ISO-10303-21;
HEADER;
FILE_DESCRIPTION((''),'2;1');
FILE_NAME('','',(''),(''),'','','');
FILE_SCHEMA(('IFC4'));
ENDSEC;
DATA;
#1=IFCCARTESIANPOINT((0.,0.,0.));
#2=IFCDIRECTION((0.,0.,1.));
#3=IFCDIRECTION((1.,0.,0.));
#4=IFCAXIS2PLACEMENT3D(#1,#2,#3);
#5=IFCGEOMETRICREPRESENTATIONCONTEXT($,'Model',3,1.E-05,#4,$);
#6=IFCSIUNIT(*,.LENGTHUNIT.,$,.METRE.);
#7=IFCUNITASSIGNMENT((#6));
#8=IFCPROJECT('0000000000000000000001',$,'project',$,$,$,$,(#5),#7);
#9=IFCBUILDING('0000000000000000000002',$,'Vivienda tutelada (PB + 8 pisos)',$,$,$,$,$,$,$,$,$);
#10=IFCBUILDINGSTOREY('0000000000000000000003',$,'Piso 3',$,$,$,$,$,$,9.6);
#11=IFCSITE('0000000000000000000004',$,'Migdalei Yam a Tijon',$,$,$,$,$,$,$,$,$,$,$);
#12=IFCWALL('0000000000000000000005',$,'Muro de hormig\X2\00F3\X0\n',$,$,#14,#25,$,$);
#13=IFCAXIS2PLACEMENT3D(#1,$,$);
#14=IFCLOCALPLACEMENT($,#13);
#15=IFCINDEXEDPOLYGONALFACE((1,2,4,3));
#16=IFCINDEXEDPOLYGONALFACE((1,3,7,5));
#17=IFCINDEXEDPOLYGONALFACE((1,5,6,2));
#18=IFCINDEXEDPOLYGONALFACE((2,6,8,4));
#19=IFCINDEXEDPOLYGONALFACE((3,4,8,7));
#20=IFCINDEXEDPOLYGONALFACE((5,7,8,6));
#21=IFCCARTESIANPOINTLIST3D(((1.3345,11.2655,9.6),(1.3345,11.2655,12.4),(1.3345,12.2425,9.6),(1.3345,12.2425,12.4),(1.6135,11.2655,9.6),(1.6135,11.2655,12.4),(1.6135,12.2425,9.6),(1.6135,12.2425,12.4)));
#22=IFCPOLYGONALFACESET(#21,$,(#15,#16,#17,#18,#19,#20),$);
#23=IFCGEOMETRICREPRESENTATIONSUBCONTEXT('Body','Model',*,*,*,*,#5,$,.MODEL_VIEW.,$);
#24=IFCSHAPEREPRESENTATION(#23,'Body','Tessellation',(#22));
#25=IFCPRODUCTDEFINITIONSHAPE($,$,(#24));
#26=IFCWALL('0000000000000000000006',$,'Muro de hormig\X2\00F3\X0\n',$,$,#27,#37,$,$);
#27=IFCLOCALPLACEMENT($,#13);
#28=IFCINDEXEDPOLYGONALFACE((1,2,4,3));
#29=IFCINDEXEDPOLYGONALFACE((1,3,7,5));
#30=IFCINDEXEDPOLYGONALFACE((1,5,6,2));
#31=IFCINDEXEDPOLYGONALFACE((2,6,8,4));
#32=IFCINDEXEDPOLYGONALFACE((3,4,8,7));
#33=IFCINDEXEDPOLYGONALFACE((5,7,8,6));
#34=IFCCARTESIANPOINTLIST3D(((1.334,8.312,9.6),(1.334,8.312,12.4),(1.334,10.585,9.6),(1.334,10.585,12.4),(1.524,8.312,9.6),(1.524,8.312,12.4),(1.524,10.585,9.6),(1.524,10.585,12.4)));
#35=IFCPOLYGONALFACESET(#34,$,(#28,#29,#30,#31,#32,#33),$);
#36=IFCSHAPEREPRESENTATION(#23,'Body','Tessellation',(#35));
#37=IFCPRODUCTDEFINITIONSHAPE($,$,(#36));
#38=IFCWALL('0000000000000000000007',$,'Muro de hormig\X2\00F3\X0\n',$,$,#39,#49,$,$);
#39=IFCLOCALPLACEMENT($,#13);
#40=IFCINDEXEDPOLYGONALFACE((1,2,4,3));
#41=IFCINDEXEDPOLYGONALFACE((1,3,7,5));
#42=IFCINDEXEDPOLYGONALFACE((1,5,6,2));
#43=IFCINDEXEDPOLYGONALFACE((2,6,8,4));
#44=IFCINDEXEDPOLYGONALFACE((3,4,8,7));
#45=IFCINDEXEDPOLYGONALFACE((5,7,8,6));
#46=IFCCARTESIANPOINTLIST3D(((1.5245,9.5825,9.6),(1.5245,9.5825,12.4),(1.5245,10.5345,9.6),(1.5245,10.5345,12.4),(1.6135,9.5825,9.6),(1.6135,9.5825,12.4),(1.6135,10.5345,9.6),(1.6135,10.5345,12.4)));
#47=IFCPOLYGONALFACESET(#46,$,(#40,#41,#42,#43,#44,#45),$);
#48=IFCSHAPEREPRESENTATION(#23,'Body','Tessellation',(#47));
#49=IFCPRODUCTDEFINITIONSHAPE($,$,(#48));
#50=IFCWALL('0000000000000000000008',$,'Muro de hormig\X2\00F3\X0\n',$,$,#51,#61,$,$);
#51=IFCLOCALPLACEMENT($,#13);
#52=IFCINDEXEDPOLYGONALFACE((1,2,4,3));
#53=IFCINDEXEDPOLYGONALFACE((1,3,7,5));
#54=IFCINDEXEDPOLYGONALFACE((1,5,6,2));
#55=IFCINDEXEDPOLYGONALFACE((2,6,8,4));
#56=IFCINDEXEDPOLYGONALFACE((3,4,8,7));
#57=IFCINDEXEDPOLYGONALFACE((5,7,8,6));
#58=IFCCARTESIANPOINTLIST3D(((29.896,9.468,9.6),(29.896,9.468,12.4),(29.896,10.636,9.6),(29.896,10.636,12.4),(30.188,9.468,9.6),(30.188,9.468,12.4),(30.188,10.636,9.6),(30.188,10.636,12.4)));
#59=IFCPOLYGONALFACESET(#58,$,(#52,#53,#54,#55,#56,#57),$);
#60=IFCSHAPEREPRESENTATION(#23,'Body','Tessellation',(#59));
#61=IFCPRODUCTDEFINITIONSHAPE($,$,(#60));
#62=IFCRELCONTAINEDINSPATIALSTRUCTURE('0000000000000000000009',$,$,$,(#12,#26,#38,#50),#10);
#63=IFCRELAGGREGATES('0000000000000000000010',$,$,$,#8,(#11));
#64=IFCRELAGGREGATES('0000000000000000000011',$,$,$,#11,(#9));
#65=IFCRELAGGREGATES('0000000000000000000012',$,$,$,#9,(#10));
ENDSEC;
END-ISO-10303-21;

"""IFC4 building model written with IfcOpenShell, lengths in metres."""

from ifc_helpers import new_model, si_unit, frame, origin_with_axes, context, subcontext, project, spatial, line, indexed_curve, outline, extrude, element, save


model = new_model("IFC4")

# Units and contexts
model_context = context("Model", 3, precision=1e-05, world=origin_with_axes())
body_context = subcontext(model_context, "Body", "Model", "MODEL_VIEW")
ifc_project = project(units=[si_unit("LENGTHUNIT", "METRE")], contexts=[model_context])

# Site, building, storey
site = spatial("IfcSite", under=ifc_project, Name="Migdalei Yam a Tijon")
building = spatial("IfcBuilding", under=site, Name="Vivienda tutelada (PB + 8 pisos)")
storey = spatial("IfcBuildingStorey", under=building, Name="Piso 3", Elevation=9.6)

# Walls
element("IfcWall", 1, inside=storey, Name="Muro de hormigón", context=body_context, shape_type="SweptSolid", body=[
    extrude(outline(indexed_curve([(0.0, 0.0), (0.279, 0.0), (0.279, 0.977), (0.0, 0.977)], segments=[line(1, 2, 3, 4, 1)])), frame((1.3345, 11.2655, 9.6), z_axis=(0.0, 0.0, 1.0), x_axis=(1.0, 0.0, 0.0)), (0.0, 0.0, 1.0), 2.8),
])
element("IfcWall", 2, inside=storey, Name="Muro de hormigón", context=body_context, shape_type="SweptSolid", body=[
    extrude(outline(indexed_curve([(0.0, 0.0), (0.19, 0.0), (0.19, 2.273), (0.0, 2.273)], segments=[line(1, 2, 3, 4, 1)])), frame((1.334, 8.312, 9.6), z_axis=(0.0, 0.0, 1.0), x_axis=(1.0, 0.0, 0.0)), (0.0, 0.0, 1.0), 2.8),
])
element("IfcWall", 3, inside=storey, Name="Muro de hormigón", context=body_context, shape_type="SweptSolid", body=[
    extrude(outline(indexed_curve([(0.0, 0.0), (0.089, 0.0), (0.089, 0.952), (0.0, 0.952)], segments=[line(1, 2, 3, 4, 1)])), frame((1.5245, 9.5825, 9.6), z_axis=(0.0, 0.0, 1.0), x_axis=(1.0, 0.0, 0.0)), (0.0, 0.0, 1.0), 2.8),
])
element("IfcWall", 4, inside=storey, Name="Muro de hormigón", context=body_context, shape_type="SweptSolid", body=[
    extrude(outline(indexed_curve([(0.0, 0.0), (0.292, 0.0), (0.292, 1.168), (0.0, 1.168)], segments=[line(1, 2, 3, 4, 1)])), frame((29.896, 9.468, 9.6), z_axis=(0.0, 0.0, 1.0), x_axis=(1.0, 0.0, 0.0)), (0.0, 0.0, 1.0), 2.8),
])

save(model, "model.ifc")
